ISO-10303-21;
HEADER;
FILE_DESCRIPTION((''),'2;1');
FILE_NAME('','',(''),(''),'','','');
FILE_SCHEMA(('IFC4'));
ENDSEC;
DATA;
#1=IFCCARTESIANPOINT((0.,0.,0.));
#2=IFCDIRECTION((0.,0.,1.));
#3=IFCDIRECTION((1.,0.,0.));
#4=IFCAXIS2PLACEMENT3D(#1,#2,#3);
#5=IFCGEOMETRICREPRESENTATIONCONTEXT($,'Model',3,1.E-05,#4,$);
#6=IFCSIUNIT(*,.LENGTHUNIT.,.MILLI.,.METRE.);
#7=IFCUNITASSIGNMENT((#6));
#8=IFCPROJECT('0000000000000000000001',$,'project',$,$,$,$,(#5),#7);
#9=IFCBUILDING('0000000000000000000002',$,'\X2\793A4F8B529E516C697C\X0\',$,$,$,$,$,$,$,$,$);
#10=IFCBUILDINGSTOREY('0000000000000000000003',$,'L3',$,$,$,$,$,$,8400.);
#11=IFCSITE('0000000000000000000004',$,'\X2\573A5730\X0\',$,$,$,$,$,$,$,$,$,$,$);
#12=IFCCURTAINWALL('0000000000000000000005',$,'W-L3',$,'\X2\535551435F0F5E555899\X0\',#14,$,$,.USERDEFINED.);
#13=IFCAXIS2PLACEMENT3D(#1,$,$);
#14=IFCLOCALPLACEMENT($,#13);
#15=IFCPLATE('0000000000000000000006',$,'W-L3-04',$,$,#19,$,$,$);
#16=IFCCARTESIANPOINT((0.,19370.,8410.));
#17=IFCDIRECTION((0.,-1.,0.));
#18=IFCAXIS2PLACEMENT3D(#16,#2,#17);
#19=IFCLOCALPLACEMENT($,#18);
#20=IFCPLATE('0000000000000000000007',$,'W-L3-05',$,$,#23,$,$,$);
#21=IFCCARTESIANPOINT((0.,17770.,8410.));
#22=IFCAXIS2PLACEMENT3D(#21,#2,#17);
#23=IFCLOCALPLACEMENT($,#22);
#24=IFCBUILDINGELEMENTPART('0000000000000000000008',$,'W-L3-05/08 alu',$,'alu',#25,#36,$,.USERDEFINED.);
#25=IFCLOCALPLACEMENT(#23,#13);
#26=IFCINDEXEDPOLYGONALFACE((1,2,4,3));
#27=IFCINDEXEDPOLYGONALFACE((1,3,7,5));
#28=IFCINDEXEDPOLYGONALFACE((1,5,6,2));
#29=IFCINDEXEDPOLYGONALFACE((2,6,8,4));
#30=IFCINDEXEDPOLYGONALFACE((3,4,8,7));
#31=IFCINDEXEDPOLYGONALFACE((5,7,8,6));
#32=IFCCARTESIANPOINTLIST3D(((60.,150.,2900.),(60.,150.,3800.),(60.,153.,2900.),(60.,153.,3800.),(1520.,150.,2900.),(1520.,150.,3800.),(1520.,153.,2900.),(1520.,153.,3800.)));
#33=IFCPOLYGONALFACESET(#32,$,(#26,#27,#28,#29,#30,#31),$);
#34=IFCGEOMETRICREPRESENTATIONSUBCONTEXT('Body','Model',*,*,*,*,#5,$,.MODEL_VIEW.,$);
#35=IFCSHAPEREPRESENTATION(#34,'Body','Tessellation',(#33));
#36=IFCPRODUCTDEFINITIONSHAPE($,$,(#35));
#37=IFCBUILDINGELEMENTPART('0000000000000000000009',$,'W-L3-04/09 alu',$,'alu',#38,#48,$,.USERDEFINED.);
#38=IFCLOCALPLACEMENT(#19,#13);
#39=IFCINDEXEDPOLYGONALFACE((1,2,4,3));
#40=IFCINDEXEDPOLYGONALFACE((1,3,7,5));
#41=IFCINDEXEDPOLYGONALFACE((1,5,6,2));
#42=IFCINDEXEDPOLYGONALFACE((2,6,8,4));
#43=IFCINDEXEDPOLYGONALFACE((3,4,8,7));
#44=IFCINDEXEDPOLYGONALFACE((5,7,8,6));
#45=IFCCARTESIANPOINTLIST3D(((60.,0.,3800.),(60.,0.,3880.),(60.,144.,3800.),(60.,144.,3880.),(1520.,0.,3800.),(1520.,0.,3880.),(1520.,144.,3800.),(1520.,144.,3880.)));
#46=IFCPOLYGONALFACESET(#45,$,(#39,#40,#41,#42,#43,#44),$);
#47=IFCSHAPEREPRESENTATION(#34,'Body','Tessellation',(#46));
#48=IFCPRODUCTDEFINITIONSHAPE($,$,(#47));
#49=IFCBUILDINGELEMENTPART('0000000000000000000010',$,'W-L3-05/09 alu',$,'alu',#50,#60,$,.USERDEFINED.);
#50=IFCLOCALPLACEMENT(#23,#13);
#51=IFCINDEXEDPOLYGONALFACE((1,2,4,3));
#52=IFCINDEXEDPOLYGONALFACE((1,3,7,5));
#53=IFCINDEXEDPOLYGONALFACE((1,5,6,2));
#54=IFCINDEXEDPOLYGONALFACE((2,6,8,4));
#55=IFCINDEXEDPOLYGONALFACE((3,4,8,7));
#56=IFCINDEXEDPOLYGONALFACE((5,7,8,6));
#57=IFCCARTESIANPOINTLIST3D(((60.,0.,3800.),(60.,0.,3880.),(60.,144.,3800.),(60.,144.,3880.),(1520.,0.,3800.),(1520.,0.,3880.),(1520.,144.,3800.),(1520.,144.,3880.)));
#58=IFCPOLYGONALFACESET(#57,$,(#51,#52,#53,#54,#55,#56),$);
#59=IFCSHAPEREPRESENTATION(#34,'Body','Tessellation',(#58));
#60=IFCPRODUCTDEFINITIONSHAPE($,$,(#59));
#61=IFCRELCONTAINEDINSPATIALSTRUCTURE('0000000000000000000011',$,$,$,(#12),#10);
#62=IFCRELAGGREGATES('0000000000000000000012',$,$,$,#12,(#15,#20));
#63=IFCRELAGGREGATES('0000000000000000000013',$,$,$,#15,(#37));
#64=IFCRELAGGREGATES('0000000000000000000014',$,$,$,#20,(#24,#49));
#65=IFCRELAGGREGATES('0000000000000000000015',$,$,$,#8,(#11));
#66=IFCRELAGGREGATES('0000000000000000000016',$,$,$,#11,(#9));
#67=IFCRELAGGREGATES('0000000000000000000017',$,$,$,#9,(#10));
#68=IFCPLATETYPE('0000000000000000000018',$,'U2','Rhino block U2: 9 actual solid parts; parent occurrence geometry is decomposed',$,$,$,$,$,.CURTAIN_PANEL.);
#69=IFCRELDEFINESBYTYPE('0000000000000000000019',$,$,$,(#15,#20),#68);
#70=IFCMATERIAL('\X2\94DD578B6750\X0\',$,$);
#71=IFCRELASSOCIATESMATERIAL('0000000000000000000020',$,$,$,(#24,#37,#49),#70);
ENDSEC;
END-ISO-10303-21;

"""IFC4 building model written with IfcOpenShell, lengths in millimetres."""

from ifc_helpers import new_model, si_unit, frame, frame_2d, origin, origin_with_axes, place, context, subcontext, project, spatial, rectangle, extrude, source, transform, mapped, material, type_object, element, aggregate, save


model = new_model("IFC4")

# Units and contexts
model_context = context("Model", 3, precision=1e-05, world=origin_with_axes())
body_context = subcontext(model_context, "Body", "Model", "MODEL_VIEW")
ifc_project = project(units=[si_unit("LENGTHUNIT", "METRE", prefix="MILLI")], contexts=[model_context])

# Site, building, storey
site = spatial("IfcSite", under=ifc_project, Name="场地")
building = spatial("IfcBuilding", under=site, Name="示例办公楼")
storey = spatial("IfcBuildingStorey", under=building, Name="L3", Elevation=8400.0)

# Curtain wall, plates, building element parts
curtain_wall = element("IfcCurtainWall", 1, inside=storey, Name="W-L3", ObjectType="单元式幕墙", PredefinedType="USERDEFINED")
plate_type = type_object("IfcPlateType", Name="U2", Description="Rhino block U2: 9 actual solid parts; parent occurrence geometry is decomposed", PredefinedType="CURTAIN_PANEL")
ifc_material_1 = material(Name="铝型材")
plate_1_placement = place(None, frame((0.0, 19370.0, 8410.0), z_axis=(0.0, 0.0, 1.0), x_axis=(0.0, -1.0, 0.0)))
plate_1 = element("IfcPlate", 2, at=plate_1_placement, type_object=plate_type, Name="W-L3-04")
plate_2_placement = place(None, frame((0.0, 17770.0, 8410.0), z_axis=(0.0, 0.0, 1.0), x_axis=(0.0, -1.0, 0.0)))
plate_2 = element("IfcPlate", 3, at=plate_2_placement, type_object=plate_type, Name="W-L3-05")
aggregate(curtain_wall, [plate_1, plate_2])
shared_shape_1 = source(origin(), body_context, "Body", "SweptSolid", [
    extrude(rectangle(XDim=1460.0, YDim=3.0, at=frame_2d((790.0, 151.5))), frame((0.0, 0.0, 2900.0)), (0.0, 0.0, 1.0), 900.0),
])
building_element_part_1_placement = place(plate_2_placement, origin())
building_element_part_1 = element("IfcBuildingElementPart", 4, at=building_element_part_1_placement, material=ifc_material_1, Name="W-L3-05/08 alu", ObjectType="alu", PredefinedType="USERDEFINED", context=body_context, shape_type="MappedRepresentation", body=[
    mapped(shared_shape_1, transform((0.0, 0.0, 0.0))),
])
shared_shape_2 = source(origin(), body_context, "Body", "SweptSolid", [
    extrude(rectangle(XDim=1460.0, YDim=144.0, at=frame_2d((790.0, 72.0))), frame((0.0, 0.0, 3800.0)), (0.0, 0.0, 1.0), 80.0),
])
building_element_part_2_placement = place(plate_1_placement, origin())
building_element_part_2 = element("IfcBuildingElementPart", 5, at=building_element_part_2_placement, material=ifc_material_1, Name="W-L3-04/09 alu", ObjectType="alu", PredefinedType="USERDEFINED", context=body_context, shape_type="MappedRepresentation", body=[
    mapped(shared_shape_2, transform((0.0, 0.0, 0.0))),
])
aggregate(plate_1, [building_element_part_2])
building_element_part_3_placement = place(plate_2_placement, origin())
building_element_part_3 = element("IfcBuildingElementPart", 6, at=building_element_part_3_placement, material=ifc_material_1, Name="W-L3-05/09 alu", ObjectType="alu", PredefinedType="USERDEFINED", context=body_context, shape_type="MappedRepresentation", body=[
    mapped(shared_shape_2, transform((0.0, 0.0, 0.0))),
])
aggregate(plate_2, [building_element_part_1, building_element_part_3])

save(model, "model.ifc")
